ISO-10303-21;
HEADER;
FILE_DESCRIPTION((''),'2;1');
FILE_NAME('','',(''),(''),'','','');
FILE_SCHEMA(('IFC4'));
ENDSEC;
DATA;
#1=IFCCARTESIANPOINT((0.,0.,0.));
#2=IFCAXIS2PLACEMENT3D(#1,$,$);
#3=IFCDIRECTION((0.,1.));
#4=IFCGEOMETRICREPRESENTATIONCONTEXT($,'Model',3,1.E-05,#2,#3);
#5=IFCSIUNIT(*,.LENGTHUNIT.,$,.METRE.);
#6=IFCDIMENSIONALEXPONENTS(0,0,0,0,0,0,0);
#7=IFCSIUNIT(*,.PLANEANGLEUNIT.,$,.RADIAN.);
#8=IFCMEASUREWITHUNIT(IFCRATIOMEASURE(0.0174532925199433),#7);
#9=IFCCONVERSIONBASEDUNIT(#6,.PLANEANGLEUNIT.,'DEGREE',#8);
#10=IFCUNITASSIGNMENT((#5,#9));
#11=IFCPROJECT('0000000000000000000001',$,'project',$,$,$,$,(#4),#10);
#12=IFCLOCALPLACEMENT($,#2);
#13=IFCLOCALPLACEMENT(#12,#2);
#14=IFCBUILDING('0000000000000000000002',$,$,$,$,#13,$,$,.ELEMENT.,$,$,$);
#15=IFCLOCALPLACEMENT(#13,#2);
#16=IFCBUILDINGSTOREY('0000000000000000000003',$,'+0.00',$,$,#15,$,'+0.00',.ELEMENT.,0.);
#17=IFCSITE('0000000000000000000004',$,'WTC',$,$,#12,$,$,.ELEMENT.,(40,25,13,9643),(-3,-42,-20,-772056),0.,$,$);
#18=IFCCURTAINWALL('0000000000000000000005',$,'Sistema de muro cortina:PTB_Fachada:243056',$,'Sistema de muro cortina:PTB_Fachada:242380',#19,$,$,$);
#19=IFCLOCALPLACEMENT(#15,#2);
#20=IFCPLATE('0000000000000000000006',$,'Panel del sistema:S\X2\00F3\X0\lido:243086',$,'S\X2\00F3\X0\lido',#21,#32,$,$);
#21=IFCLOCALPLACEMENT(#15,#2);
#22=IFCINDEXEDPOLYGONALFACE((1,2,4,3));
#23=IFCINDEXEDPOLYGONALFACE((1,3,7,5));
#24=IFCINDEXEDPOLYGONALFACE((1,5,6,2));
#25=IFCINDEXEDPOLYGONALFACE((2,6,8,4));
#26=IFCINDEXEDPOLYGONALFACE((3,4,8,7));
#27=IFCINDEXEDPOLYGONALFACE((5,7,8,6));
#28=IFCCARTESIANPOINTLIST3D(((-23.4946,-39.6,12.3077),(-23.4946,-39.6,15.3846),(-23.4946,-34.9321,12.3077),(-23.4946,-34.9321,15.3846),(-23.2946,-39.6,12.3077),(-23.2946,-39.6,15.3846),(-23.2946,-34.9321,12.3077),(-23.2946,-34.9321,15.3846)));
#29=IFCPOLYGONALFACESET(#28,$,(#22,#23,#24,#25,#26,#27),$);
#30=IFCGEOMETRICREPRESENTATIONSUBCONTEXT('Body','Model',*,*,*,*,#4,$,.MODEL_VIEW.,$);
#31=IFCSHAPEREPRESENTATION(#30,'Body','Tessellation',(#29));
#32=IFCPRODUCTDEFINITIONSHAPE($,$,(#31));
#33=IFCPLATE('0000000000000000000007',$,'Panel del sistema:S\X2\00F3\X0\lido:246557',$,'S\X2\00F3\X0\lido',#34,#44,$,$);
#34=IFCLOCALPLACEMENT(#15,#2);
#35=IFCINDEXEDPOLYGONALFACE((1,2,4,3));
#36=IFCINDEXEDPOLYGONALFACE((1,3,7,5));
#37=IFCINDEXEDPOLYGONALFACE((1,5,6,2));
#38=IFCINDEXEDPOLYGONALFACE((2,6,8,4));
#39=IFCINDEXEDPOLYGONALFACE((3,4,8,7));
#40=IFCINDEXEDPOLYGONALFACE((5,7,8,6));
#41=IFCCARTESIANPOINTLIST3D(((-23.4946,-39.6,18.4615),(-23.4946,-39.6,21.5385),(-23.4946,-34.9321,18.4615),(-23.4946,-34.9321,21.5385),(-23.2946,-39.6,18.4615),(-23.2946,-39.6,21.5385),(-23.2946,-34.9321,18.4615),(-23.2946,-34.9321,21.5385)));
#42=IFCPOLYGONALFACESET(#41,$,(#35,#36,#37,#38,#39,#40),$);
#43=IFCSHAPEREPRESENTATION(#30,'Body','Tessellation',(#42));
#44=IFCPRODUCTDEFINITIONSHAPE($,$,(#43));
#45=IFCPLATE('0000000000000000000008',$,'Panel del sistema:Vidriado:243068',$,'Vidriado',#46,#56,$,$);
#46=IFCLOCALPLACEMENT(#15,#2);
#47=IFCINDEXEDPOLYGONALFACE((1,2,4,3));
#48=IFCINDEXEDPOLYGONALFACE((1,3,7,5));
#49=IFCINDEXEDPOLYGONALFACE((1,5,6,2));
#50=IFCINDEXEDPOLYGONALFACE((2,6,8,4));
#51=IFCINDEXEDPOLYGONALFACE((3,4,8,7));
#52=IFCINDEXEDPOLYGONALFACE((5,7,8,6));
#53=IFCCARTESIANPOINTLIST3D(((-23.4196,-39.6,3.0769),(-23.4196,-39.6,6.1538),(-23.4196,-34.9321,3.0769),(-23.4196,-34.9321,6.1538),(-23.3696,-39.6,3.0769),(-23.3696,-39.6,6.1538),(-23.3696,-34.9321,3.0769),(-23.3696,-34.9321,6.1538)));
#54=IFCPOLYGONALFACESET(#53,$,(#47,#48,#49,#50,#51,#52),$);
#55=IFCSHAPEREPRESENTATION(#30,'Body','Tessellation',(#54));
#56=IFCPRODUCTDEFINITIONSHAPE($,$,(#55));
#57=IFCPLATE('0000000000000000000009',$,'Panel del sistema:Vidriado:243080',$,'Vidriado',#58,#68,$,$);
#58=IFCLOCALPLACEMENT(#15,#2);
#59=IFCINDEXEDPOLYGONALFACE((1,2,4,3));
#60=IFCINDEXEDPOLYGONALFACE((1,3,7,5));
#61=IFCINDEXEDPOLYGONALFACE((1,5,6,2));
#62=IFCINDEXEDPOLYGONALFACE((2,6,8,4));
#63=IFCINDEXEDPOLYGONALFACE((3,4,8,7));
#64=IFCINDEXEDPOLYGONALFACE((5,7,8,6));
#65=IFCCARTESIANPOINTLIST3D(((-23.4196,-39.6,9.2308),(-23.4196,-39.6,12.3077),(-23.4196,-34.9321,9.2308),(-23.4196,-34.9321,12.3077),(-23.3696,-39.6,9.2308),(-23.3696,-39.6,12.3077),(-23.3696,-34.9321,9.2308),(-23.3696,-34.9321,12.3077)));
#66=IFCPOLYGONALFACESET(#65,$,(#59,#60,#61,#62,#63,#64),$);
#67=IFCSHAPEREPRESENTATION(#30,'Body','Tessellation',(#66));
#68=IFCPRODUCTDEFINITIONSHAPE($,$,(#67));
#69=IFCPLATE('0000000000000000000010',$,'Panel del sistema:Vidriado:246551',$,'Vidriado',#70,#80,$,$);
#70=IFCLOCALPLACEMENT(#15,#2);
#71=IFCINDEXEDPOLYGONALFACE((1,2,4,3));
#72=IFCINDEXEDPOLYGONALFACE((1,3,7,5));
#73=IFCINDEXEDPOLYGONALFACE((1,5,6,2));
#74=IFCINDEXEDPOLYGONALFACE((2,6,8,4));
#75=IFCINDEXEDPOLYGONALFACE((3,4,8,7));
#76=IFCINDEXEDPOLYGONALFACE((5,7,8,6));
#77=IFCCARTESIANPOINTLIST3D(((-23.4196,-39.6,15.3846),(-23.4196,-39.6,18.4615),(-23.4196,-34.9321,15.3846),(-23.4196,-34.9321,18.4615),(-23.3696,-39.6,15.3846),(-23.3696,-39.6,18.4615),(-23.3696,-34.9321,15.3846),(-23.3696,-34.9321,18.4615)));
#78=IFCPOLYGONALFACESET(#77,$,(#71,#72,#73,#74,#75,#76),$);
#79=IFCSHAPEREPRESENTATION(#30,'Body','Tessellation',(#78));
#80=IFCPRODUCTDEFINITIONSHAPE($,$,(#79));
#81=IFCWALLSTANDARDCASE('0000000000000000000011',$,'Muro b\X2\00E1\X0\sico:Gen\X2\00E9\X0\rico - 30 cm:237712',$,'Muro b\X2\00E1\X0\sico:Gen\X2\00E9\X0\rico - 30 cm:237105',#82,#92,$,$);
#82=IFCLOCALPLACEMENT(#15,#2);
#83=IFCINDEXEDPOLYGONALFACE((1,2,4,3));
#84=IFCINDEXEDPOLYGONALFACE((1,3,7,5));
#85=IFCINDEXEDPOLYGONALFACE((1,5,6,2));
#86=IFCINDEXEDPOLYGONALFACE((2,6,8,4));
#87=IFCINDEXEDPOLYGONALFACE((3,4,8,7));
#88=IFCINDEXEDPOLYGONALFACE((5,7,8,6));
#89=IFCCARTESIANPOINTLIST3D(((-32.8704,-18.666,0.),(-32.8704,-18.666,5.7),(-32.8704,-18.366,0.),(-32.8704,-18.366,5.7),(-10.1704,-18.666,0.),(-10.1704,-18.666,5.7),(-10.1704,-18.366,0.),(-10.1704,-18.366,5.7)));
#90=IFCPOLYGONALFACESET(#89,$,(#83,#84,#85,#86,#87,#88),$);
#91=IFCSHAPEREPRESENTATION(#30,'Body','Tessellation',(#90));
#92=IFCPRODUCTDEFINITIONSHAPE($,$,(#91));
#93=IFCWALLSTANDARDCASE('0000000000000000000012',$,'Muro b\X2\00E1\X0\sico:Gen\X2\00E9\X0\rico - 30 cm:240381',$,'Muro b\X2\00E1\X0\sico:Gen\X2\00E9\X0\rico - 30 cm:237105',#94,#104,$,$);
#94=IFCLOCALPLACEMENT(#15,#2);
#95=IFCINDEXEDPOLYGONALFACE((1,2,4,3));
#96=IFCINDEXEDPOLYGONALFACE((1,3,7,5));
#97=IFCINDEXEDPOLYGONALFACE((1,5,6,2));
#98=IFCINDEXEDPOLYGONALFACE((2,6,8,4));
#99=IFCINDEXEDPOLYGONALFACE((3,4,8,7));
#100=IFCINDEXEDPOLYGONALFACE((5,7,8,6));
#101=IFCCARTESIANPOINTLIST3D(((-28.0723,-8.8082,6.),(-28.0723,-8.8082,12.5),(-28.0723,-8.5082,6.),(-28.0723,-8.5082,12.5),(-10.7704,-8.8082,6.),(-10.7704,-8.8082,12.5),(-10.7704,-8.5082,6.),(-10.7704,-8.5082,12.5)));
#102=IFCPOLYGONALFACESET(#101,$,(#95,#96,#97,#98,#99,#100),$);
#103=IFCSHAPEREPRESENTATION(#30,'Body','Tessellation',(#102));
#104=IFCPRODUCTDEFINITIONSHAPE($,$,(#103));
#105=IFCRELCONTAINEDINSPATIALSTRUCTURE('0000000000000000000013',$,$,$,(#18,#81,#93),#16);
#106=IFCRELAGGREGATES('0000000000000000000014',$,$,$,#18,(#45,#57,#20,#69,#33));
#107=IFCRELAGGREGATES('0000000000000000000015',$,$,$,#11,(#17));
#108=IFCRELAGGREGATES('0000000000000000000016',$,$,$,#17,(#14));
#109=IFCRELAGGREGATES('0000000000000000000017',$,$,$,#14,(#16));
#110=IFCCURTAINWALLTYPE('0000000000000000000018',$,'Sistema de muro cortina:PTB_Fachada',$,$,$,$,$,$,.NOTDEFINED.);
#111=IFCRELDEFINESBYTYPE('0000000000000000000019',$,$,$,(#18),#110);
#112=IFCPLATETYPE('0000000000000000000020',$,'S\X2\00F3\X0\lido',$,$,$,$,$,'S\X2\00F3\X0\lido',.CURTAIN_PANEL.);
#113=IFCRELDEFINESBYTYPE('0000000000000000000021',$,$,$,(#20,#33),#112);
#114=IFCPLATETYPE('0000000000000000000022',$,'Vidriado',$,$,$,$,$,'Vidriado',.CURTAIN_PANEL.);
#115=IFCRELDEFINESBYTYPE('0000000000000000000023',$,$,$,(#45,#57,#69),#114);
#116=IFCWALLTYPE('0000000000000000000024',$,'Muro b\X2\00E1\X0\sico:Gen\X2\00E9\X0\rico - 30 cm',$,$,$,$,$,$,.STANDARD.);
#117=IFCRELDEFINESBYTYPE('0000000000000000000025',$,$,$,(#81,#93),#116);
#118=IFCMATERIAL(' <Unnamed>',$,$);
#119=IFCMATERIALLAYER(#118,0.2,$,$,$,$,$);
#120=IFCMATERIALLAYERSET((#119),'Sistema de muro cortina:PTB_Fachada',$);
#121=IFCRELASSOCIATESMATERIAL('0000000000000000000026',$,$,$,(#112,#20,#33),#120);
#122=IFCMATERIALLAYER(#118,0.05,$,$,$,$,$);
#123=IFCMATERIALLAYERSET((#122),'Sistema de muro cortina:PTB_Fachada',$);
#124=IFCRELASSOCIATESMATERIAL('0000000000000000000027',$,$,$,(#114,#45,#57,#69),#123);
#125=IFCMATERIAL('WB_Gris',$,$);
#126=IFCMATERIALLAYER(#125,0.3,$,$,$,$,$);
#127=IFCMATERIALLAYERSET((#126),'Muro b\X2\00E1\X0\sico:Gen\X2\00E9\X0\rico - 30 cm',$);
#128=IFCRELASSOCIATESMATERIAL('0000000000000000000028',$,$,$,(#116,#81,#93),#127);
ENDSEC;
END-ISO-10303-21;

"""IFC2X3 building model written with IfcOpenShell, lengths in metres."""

from ifc_helpers import new_model, entity, si_unit, converted_unit, direction, frame, frame_2d, origin, origin_2d_with_axis, place, context, subcontext, project, spatial, polyline, rectangle, extrude, clip, bounded_halfspace, source, transform, mapped, material, layer, layer_set, layer_usage, type_object, type_shapes, element, aggregate, save


model = new_model("IFC2X3")

# Units and contexts
model_context = context("Model", 3, precision=1e-05, world=origin(), true_north=direction((0.0, 1.0)))
body_context = subcontext(model_context, "Body", "Model", "MODEL_VIEW")
ifc_project = project(units=[si_unit("LENGTHUNIT", "METRE"), converted_unit("PLANEANGLEUNIT", "DEGREE", entity("IfcRatioMeasure", 0.0174532925199433), si_unit("PLANEANGLEUNIT", "RADIAN"), dimensions=[0, 0, 0, 0, 0, 0, 0])], contexts=[model_context])

# Site, building, storey
site_placement = place(None, origin())
site = spatial("IfcSite", under=ifc_project, at=site_placement, Name="WTC", CompositionType="ELEMENT", RefLatitude=(40, 25, 13, 9643), RefLongitude=(-3, -42, -20, -772056), RefElevation=0.0)
building_placement = place(site_placement, origin())
building = spatial("IfcBuilding", under=site, at=building_placement, CompositionType="ELEMENT")
storey_placement = place(building_placement, origin())
storey = spatial("IfcBuildingStorey", under=building, at=storey_placement, Name="+0.00", LongName="+0.00", CompositionType="ELEMENT", Elevation=0.0)

# Curtain wall, plates
curtain_wall_type = type_object("IfcCurtainWallType", Name="Sistema de muro cortina:PTB_Fachada", PredefinedType="NOTDEFINED")
ifc_material_1 = material(Name=" <Unnamed>")
ifc_layer_1 = layer(ifc_material_1, 0.2)
ifc_layer_set_1 = layer_set([ifc_layer_1], Name="Sistema de muro cortina:PTB_Fachada")
ifc_layer_2 = layer(ifc_material_1, 0.05)
ifc_layer_set_2 = layer_set([ifc_layer_2], Name="Sistema de muro cortina:PTB_Fachada")
curtain_wall_1_placement = place(storey_placement, origin())
curtain_wall_1 = element("IfcCurtainWall", 1, at=curtain_wall_1_placement, inside=storey, type_object=curtain_wall_type, Name="Sistema de muro cortina:PTB_Fachada:243056", ObjectType="Sistema de muro cortina:PTB_Fachada:242380")
plate_type_1 = type_object("IfcPlateType", Name="Sólido", ElementType="Sólido", PredefinedType="CURTAIN_PANEL", material=ifc_layer_set_1)
shared_shape_1 = source(origin(), body_context, "Body", "SweptSolid", [
    extrude(rectangle(XDim=0.2, YDim=4.6679, at=origin_2d_with_axis()), frame((0.0, 0.0, 0.0), z_axis=(0.0, 0.0, 1.0), x_axis=(0.0, 1.0, 0.0)), (0.0, 0.0, 1.0), 3.0769),
])
type_shapes(plate_type_1, [shared_shape_1])
ifc_layer_usage_1 = layer_usage(ifc_layer_set_1, "AXIS3", "POSITIVE", 0.0)
plate_1_placement = place(curtain_wall_1_placement, frame((-23.3946, -37.266, 12.3077), z_axis=(0.0, 0.0, 1.0), x_axis=(0.0, -1.0, 0.0)))
plate_1 = element("IfcPlate", 2, at=plate_1_placement, type_object=plate_type_1, material=ifc_layer_usage_1, Name="Panel del sistema:Sólido:243086", ObjectType="Sólido", context=body_context, shape_type="MappedRepresentation", body=[
    mapped(shared_shape_1, transform((0.0, 0.0, 0.0), scale=1.0)),
])
ifc_layer_usage_2 = layer_usage(ifc_layer_set_1, "AXIS3", "POSITIVE", 0.0)
plate_2_placement = place(curtain_wall_1_placement, frame((-23.3946, -37.266, 18.4615), z_axis=(0.0, 0.0, 1.0), x_axis=(0.0, -1.0, 0.0)))
plate_2 = element("IfcPlate", 3, at=plate_2_placement, type_object=plate_type_1, material=ifc_layer_usage_2, Name="Panel del sistema:Sólido:246557", ObjectType="Sólido", context=body_context, shape_type="MappedRepresentation", body=[
    mapped(shared_shape_1, transform((0.0, 0.0, 0.0), scale=1.0)),
])
ifc_layer_usage_3 = layer_usage(ifc_layer_set_2, "AXIS3", "POSITIVE", 0.0)
plate_type_2 = type_object("IfcPlateType", Name="Vidriado", ElementType="Vidriado", PredefinedType="CURTAIN_PANEL", material=ifc_layer_set_2)
shared_shape_2 = source(origin(), body_context, "Body", "SweptSolid", [
    extrude(rectangle(XDim=0.05, YDim=4.6679, at=origin_2d_with_axis()), frame((0.0, 0.0, 0.0), z_axis=(0.0, 0.0, 1.0), x_axis=(0.0, 1.0, 0.0)), (0.0, 0.0, 1.0), 3.0769),
])
type_shapes(plate_type_2, [shared_shape_2])
plate_3_placement = place(curtain_wall_1_placement, frame((-23.3946, -37.266, 3.0769), z_axis=(0.0, 0.0, 1.0), x_axis=(0.0, -1.0, 0.0)))
plate_3 = element("IfcPlate", 4, at=plate_3_placement, type_object=plate_type_2, material=ifc_layer_usage_3, Name="Panel del sistema:Vidriado:243068", ObjectType="Vidriado", context=body_context, shape_type="MappedRepresentation", body=[
    mapped(shared_shape_2, transform((0.0, 0.0, 0.0), scale=1.0)),
])
ifc_layer_usage_4 = layer_usage(ifc_layer_set_2, "AXIS3", "POSITIVE", 0.0)
plate_4_placement = place(curtain_wall_1_placement, frame((-23.3946, -37.266, 9.2308), z_axis=(0.0, 0.0, 1.0), x_axis=(0.0, -1.0, 0.0)))
plate_4 = element("IfcPlate", 5, at=plate_4_placement, type_object=plate_type_2, material=ifc_layer_usage_4, Name="Panel del sistema:Vidriado:243080", ObjectType="Vidriado", context=body_context, shape_type="MappedRepresentation", body=[
    mapped(shared_shape_2, transform((0.0, 0.0, 0.0), scale=1.0)),
])
ifc_layer_usage_5 = layer_usage(ifc_layer_set_2, "AXIS3", "POSITIVE", 0.0)
plate_5_placement = place(curtain_wall_1_placement, frame((-23.3946, -37.266, 15.3846), z_axis=(0.0, 0.0, 1.0), x_axis=(0.0, -1.0, 0.0)))
plate_5 = element("IfcPlate", 6, at=plate_5_placement, type_object=plate_type_2, material=ifc_layer_usage_5, Name="Panel del sistema:Vidriado:246551", ObjectType="Vidriado", context=body_context, shape_type="MappedRepresentation", body=[
    mapped(shared_shape_2, transform((0.0, 0.0, 0.0), scale=1.0)),
])
aggregate(curtain_wall_1, [plate_3, plate_4, plate_1, plate_5, plate_2])

# Walls
ifc_material_2 = material(Name="WB_Gris")
ifc_layer_3 = layer(ifc_material_2, 0.3)
ifc_layer_set_3 = layer_set([ifc_layer_3], Name="Muro básico:Genérico - 30 cm")
ifc_layer_usage_6 = layer_usage(ifc_layer_set_3, "AXIS2", "POSITIVE", -0.15)
wall_type = type_object("IfcWallType", Name="Muro básico:Genérico - 30 cm", PredefinedType="STANDARD", material=ifc_layer_set_3)
wall_1_placement = place(storey_placement, frame((-32.8704, -18.516, 0.0)))
element("IfcWallStandardCase", 7, at=wall_1_placement, inside=storey, type_object=wall_type, material=ifc_layer_usage_6, Name="Muro básico:Genérico - 30 cm:237712", ObjectType="Muro básico:Genérico - 30 cm:237105", context=body_context, shape_type="Clipping", body=[
    clip(extrude(rectangle(XDim=22.7, YDim=0.3, at=frame_2d((11.35, 0.0), x_axis=(-1.0, 0.0))), origin(), (0.0, 0.0, 1.0), 5.7), bounded_halfspace(frame((22.4, -0.15, 5.7), z_axis=(0.0, 0.0, 1.0), x_axis=(0.0, 1.0, 0.0)), False, frame((22.4, -0.15, 5.7), z_axis=(0.0, 0.0, 1.0), x_axis=(0.0, 1.0, 0.0)), polyline([(0.0, 0.0), (0.0, -0.3), (0.3, -0.3), (0.3, 22.4), (0.0, 22.4), (0.0, 0.0)]))),
])
ifc_layer_usage_7 = layer_usage(ifc_layer_set_3, "AXIS2", "POSITIVE", -0.15)
wall_2_placement = place(storey_placement, frame((-28.0723, -8.6582, 6.0)))
element("IfcWallStandardCase", 8, at=wall_2_placement, inside=storey, type_object=wall_type, material=ifc_layer_usage_7, Name="Muro básico:Genérico - 30 cm:240381", ObjectType="Muro básico:Genérico - 30 cm:237105", context=body_context, shape_type="SweptSolid", body=[
    extrude(rectangle(XDim=17.3019, YDim=0.3, at=frame_2d((8.651, 0.0), x_axis=(-1.0, 0.0))), origin(), (0.0, 0.0, 1.0), 6.5),
])

save(model, "model.ifc")
